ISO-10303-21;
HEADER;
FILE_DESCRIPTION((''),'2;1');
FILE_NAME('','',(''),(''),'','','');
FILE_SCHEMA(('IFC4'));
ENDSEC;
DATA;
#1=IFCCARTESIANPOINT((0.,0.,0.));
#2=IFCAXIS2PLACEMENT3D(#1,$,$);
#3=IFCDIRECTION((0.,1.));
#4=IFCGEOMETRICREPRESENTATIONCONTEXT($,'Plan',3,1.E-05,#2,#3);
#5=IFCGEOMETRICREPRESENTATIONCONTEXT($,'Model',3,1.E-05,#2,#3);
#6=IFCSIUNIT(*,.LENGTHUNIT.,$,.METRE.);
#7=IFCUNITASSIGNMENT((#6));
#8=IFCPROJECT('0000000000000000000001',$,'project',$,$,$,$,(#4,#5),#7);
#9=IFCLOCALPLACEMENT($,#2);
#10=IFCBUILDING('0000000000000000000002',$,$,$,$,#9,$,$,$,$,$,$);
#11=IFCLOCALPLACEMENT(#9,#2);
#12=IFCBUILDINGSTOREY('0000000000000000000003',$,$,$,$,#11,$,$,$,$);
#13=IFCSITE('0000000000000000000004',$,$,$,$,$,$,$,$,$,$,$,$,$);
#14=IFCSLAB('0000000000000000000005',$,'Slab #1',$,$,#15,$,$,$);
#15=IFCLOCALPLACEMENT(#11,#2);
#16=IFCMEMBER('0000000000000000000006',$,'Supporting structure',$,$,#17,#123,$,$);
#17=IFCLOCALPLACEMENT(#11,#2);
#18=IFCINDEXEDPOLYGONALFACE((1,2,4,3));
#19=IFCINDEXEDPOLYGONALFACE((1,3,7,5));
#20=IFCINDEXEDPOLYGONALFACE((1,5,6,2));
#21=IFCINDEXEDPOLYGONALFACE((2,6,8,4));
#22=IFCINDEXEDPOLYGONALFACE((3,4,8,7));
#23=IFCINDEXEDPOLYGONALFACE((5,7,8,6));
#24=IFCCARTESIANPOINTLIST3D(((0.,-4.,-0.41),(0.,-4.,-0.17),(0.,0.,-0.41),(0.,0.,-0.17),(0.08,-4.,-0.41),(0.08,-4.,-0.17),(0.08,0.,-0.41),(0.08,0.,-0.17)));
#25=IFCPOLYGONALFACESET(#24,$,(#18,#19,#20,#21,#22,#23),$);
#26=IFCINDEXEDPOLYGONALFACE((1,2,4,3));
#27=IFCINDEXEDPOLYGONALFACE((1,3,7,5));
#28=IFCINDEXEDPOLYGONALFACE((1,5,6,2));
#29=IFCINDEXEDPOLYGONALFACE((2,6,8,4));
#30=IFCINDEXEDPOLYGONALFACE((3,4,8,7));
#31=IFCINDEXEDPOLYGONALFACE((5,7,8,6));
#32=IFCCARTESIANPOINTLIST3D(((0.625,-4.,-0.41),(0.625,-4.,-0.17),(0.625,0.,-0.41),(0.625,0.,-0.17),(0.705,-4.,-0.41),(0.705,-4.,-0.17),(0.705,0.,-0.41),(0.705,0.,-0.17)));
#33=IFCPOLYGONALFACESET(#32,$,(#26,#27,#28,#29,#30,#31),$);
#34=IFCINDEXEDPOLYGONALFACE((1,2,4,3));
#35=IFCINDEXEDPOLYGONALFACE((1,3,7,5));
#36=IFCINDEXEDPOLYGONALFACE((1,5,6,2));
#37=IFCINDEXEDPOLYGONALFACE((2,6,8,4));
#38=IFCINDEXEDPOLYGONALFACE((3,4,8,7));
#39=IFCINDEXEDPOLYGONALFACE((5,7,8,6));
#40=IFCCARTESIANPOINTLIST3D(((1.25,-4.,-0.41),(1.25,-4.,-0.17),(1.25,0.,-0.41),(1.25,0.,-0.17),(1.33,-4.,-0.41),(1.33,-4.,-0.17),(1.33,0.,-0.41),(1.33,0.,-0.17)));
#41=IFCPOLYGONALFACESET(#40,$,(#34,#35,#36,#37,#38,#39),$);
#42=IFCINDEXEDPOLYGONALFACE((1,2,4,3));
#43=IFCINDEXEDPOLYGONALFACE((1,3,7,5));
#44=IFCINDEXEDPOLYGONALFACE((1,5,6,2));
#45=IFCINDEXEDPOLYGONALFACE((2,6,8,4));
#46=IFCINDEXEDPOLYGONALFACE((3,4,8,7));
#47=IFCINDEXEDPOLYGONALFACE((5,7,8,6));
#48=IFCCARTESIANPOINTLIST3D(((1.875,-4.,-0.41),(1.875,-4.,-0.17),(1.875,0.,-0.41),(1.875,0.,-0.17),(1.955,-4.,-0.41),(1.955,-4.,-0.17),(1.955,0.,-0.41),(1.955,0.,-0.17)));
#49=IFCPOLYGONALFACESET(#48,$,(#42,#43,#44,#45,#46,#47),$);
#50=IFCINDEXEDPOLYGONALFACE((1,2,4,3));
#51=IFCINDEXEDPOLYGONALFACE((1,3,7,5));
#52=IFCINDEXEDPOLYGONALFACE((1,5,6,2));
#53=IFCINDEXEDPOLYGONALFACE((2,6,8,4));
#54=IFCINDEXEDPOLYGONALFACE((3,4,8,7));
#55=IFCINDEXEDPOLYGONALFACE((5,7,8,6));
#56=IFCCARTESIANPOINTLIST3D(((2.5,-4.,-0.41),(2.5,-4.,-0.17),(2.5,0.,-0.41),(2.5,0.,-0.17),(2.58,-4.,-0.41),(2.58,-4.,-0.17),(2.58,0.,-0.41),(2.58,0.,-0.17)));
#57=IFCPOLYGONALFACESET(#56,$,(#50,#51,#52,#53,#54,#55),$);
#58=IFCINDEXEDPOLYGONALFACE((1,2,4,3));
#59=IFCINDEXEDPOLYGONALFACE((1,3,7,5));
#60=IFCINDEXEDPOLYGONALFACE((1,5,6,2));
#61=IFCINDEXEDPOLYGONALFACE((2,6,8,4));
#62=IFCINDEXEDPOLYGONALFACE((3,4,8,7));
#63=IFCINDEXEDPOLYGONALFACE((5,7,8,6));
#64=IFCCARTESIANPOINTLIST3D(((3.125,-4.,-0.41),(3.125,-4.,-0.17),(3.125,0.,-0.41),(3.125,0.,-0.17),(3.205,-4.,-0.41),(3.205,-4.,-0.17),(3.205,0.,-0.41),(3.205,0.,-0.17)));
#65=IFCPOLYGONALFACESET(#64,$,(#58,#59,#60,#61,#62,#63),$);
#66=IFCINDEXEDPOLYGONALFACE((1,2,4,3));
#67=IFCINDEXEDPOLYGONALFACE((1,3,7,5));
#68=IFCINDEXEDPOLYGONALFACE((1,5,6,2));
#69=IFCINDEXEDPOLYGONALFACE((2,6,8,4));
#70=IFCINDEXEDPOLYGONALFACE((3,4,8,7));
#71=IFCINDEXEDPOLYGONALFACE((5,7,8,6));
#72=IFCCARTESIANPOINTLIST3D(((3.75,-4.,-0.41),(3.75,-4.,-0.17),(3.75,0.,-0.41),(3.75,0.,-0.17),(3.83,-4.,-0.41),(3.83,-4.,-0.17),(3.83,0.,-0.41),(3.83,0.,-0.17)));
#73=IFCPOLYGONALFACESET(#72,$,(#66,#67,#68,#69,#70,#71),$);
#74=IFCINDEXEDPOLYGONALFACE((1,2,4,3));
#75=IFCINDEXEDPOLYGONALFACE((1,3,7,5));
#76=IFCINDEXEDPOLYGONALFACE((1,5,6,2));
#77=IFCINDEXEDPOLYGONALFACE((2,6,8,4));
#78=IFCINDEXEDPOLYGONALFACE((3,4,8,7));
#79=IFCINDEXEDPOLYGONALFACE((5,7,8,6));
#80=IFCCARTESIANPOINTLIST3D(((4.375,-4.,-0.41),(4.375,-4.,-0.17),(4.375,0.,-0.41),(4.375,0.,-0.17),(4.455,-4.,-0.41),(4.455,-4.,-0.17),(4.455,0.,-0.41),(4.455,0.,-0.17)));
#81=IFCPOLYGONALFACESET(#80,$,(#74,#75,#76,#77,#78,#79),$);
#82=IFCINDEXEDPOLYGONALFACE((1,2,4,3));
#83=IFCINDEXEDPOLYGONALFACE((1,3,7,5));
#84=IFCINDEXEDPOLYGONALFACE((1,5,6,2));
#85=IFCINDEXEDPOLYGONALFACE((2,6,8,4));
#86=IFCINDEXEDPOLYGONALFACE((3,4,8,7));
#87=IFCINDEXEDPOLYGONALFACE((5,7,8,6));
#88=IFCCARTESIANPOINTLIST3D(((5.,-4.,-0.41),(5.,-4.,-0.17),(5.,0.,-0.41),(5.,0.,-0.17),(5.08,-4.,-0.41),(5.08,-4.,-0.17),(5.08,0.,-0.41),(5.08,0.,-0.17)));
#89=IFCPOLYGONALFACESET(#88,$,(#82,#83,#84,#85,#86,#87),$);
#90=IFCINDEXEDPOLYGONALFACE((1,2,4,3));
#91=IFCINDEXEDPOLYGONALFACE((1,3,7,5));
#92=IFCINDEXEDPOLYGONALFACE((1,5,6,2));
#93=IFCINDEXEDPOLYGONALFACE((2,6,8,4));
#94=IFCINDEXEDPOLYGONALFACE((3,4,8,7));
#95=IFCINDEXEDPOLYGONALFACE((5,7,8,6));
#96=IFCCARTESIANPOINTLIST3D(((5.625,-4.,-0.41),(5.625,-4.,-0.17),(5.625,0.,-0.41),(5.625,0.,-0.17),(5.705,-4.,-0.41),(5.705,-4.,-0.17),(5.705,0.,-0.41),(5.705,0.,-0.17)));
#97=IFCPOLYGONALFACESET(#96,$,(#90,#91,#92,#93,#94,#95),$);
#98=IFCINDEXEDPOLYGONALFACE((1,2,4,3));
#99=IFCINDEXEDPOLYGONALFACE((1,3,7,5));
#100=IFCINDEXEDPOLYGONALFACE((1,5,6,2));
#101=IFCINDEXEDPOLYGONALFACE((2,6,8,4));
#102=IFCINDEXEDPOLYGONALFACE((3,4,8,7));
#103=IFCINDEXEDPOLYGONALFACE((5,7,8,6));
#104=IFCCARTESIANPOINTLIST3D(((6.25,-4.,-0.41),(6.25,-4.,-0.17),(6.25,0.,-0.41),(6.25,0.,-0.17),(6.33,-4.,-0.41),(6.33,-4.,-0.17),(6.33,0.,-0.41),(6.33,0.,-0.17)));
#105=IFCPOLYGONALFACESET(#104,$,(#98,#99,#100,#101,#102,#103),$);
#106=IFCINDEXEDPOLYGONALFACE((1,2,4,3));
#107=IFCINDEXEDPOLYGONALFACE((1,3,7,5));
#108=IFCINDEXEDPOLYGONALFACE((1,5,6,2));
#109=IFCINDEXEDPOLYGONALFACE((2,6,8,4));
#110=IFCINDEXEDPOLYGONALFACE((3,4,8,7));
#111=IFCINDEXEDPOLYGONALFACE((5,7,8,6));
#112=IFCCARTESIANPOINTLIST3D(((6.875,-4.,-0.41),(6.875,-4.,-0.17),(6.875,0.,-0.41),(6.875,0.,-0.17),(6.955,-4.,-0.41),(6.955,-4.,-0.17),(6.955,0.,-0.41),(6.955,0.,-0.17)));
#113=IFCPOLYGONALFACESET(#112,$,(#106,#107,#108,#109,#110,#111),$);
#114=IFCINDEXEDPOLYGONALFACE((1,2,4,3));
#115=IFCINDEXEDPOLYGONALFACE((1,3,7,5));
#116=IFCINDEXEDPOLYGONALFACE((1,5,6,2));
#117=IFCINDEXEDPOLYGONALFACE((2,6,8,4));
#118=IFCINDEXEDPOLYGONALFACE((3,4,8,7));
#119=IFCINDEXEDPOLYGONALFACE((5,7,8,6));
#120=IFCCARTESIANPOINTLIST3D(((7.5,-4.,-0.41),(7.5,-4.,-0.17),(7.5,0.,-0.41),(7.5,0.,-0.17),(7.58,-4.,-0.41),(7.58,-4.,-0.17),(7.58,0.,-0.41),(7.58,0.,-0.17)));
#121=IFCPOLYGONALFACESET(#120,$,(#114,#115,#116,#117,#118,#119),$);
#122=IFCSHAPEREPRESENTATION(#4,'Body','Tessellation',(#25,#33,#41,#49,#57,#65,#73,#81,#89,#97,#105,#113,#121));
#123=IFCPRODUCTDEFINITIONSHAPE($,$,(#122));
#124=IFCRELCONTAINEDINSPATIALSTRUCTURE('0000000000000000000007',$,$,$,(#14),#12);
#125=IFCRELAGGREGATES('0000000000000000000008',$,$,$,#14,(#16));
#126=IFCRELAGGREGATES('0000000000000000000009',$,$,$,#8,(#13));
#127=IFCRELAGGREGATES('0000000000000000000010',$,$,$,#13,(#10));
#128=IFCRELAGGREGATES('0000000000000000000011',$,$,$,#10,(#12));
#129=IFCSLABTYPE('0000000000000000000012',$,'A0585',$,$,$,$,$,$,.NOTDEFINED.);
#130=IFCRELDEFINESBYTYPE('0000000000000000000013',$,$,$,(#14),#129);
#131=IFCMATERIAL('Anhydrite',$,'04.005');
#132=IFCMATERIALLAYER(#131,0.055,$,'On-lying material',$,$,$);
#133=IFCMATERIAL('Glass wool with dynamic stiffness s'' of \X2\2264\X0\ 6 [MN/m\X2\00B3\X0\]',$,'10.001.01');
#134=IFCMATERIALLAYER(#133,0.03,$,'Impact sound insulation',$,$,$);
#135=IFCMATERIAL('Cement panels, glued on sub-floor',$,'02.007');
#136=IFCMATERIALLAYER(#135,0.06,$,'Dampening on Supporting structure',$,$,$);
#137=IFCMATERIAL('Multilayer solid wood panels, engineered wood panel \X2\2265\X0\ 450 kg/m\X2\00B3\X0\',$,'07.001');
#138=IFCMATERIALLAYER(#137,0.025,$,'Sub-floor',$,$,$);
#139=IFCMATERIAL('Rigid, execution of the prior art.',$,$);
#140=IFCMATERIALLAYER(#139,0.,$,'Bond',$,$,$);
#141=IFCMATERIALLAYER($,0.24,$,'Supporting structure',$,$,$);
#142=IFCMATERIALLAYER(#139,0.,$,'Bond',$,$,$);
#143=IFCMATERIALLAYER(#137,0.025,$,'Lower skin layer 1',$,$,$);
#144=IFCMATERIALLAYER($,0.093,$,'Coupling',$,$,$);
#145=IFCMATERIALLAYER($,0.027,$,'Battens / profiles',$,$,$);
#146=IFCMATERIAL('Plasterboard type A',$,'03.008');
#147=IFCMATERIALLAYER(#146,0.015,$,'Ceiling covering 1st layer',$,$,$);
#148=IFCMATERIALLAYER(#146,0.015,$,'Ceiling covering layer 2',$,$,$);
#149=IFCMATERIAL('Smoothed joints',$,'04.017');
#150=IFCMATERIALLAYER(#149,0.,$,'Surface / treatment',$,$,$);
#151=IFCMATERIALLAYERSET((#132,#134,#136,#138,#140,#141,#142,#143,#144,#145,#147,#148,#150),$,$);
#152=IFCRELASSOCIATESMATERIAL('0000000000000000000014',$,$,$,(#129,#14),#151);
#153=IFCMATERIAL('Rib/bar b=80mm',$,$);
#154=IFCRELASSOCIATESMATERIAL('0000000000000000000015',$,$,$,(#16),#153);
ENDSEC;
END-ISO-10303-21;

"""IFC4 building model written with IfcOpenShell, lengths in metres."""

from ifc_helpers import new_model, si_unit, direction, frame, frame_2d, origin, place, context, project, spatial, rectangle, extrude, material, layer, layer_set, type_object, element, aggregate, save


model = new_model("IFC4")

# Units and contexts
plan_context = context("Plan", 3, precision=1e-05, world=origin(), true_north=direction((0.0, 1.0)))
model_context = context("Model", 3, precision=1e-05, world=origin(), true_north=direction((0.0, 1.0)))
ifc_project = project(units=[si_unit("LENGTHUNIT", "METRE")], contexts=[plan_context, model_context])

# Site, building, storey
site = spatial("IfcSite", under=ifc_project)
building_placement = place(None, origin())
building = spatial("IfcBuilding", under=site, at=building_placement)
storey_placement = place(building_placement, origin())
storey = spatial("IfcBuildingStorey", under=building, at=storey_placement)

# Slab, member
ifc_material_1 = material(Name="Anhydrite", Category="04.005")
ifc_layer_1 = layer(ifc_material_1, 0.055, Name="On-lying material")
ifc_material_2 = material(Name="Glass wool with dynamic stiffness s' of ≤ 6 [MN/m³]", Category="10.001.01")
ifc_layer_2 = layer(ifc_material_2, 0.03, Name="Impact sound insulation")
ifc_material_3 = material(Name="Cement panels, glued on sub-floor", Category="02.007")
ifc_layer_3 = layer(ifc_material_3, 0.06, Name="Dampening on Supporting structure")
ifc_material_4 = material(Name="Multilayer solid wood panels, engineered wood panel ≥ 450 kg/m³", Category="07.001")
ifc_layer_4 = layer(ifc_material_4, 0.025, Name="Sub-floor")
ifc_material_5 = material(Name="Rigid, execution of the prior art.")
ifc_layer_5 = layer(ifc_material_5, 0.0, Name="Bond")
ifc_layer_6 = layer(None, 0.24, Name="Supporting structure")
ifc_layer_7 = layer(ifc_material_5, 0.0, Name="Bond")
ifc_layer_8 = layer(ifc_material_4, 0.025, Name="Lower skin layer 1")
ifc_layer_9 = layer(None, 0.093, Name="Coupling")
ifc_layer_10 = layer(None, 0.027, Name="Battens / profiles")
ifc_material_6 = material(Name="Plasterboard type A", Category="03.008")
ifc_layer_11 = layer(ifc_material_6, 0.015, Name="Ceiling covering 1st layer")
ifc_layer_12 = layer(ifc_material_6, 0.015, Name="Ceiling covering layer 2")
ifc_material_7 = material(Name="Smoothed joints", Category="04.017")
ifc_layer_13 = layer(ifc_material_7, 0.0, Name="Surface / treatment")
ifc_layer_set = layer_set([ifc_layer_1, ifc_layer_2, ifc_layer_3, ifc_layer_4, ifc_layer_5, ifc_layer_6, ifc_layer_7, ifc_layer_8, ifc_layer_9, ifc_layer_10, ifc_layer_11, ifc_layer_12, ifc_layer_13])
slab_type = type_object("IfcSlabType", Name="A0585", PredefinedType="NOTDEFINED", material=ifc_layer_set)
slab_placement = place(None, frame((0.0, 0.0, 0.0), z_axis=(0.0, 0.0, -1.0), x_axis=(1.0, 0.0, 0.0)))
slab = element("IfcSlab", 1, at=slab_placement, inside=storey, type_object=slab_type, material=ifc_layer_set, Name="Slab #1")
ifc_material_8 = material(Name="Rib/bar b=80mm")
member_1_placement = place(slab_placement, origin())
member_1 = element("IfcMember", 2, at=member_1_placement, material=ifc_material_8, Name="Supporting structure", context=plan_context, shape_type="SweptSolid", body=[
    extrude(rectangle(XDim=0.08, YDim=0.24, at=frame_2d((0.04, 0.12), x_axis=(1.0, 0.0))), frame((0.0, 4.0, 0.17), z_axis=(0.0, -1.0, 0.0), x_axis=(1.0, 0.0, 0.0)), (0.0, 0.0, 1.0), 4.0),
    extrude(rectangle(XDim=0.08, YDim=0.24, at=frame_2d((0.04, 0.12), x_axis=(1.0, 0.0))), frame((0.625, 4.0, 0.17), z_axis=(0.0, -1.0, 0.0), x_axis=(1.0, 0.0, 0.0)), (0.0, 0.0, 1.0), 4.0),
    extrude(rectangle(XDim=0.08, YDim=0.24, at=frame_2d((0.04, 0.12), x_axis=(1.0, 0.0))), frame((1.25, 4.0, 0.17), z_axis=(0.0, -1.0, 0.0), x_axis=(1.0, 0.0, 0.0)), (0.0, 0.0, 1.0), 4.0),
    extrude(rectangle(XDim=0.08, YDim=0.24, at=frame_2d((0.04, 0.12), x_axis=(1.0, 0.0))), frame((1.875, 4.0, 0.17), z_axis=(0.0, -1.0, 0.0), x_axis=(1.0, 0.0, 0.0)), (0.0, 0.0, 1.0), 4.0),
    extrude(rectangle(XDim=0.08, YDim=0.24, at=frame_2d((0.04, 0.12), x_axis=(1.0, 0.0))), frame((2.5, 4.0, 0.17), z_axis=(0.0, -1.0, 0.0), x_axis=(1.0, 0.0, 0.0)), (0.0, 0.0, 1.0), 4.0),
    extrude(rectangle(XDim=0.08, YDim=0.24, at=frame_2d((0.04, 0.12), x_axis=(1.0, 0.0))), frame((3.125, 4.0, 0.17), z_axis=(0.0, -1.0, 0.0), x_axis=(1.0, 0.0, 0.0)), (0.0, 0.0, 1.0), 4.0),
    extrude(rectangle(XDim=0.08, YDim=0.24, at=frame_2d((0.04, 0.12), x_axis=(1.0, 0.0))), frame((3.75, 4.0, 0.17), z_axis=(0.0, -1.0, 0.0), x_axis=(1.0, 0.0, 0.0)), (0.0, 0.0, 1.0), 4.0),
    extrude(rectangle(XDim=0.08, YDim=0.24, at=frame_2d((0.04, 0.12), x_axis=(1.0, 0.0))), frame((4.375, 4.0, 0.17), z_axis=(0.0, -1.0, 0.0), x_axis=(1.0, 0.0, 0.0)), (0.0, 0.0, 1.0), 4.0),
    extrude(rectangle(XDim=0.08, YDim=0.24, at=frame_2d((0.04, 0.12), x_axis=(1.0, 0.0))), frame((5.0, 4.0, 0.17), z_axis=(0.0, -1.0, 0.0), x_axis=(1.0, 0.0, 0.0)), (0.0, 0.0, 1.0), 4.0),
    extrude(rectangle(XDim=0.08, YDim=0.24, at=frame_2d((0.04, 0.12), x_axis=(1.0, 0.0))), frame((5.625, 4.0, 0.17), z_axis=(0.0, -1.0, 0.0), x_axis=(1.0, 0.0, 0.0)), (0.0, 0.0, 1.0), 4.0),
    extrude(rectangle(XDim=0.08, YDim=0.24, at=frame_2d((0.04, 0.12), x_axis=(1.0, 0.0))), frame((6.25, 4.0, 0.17), z_axis=(0.0, -1.0, 0.0), x_axis=(1.0, 0.0, 0.0)), (0.0, 0.0, 1.0), 4.0),
    extrude(rectangle(XDim=0.08, YDim=0.24, at=frame_2d((0.04, 0.12), x_axis=(1.0, 0.0))), frame((6.875, 4.0, 0.17), z_axis=(0.0, -1.0, 0.0), x_axis=(1.0, 0.0, 0.0)), (0.0, 0.0, 1.0), 4.0),
    extrude(rectangle(XDim=0.08, YDim=0.24, at=frame_2d((0.04, 0.12), x_axis=(1.0, 0.0))), frame((7.5, 4.0, 0.17), z_axis=(0.0, -1.0, 0.0), x_axis=(1.0, 0.0, 0.0)), (0.0, 0.0, 1.0), 4.0),
])
aggregate(slab, [member_1])

save(model, "model.ifc")
